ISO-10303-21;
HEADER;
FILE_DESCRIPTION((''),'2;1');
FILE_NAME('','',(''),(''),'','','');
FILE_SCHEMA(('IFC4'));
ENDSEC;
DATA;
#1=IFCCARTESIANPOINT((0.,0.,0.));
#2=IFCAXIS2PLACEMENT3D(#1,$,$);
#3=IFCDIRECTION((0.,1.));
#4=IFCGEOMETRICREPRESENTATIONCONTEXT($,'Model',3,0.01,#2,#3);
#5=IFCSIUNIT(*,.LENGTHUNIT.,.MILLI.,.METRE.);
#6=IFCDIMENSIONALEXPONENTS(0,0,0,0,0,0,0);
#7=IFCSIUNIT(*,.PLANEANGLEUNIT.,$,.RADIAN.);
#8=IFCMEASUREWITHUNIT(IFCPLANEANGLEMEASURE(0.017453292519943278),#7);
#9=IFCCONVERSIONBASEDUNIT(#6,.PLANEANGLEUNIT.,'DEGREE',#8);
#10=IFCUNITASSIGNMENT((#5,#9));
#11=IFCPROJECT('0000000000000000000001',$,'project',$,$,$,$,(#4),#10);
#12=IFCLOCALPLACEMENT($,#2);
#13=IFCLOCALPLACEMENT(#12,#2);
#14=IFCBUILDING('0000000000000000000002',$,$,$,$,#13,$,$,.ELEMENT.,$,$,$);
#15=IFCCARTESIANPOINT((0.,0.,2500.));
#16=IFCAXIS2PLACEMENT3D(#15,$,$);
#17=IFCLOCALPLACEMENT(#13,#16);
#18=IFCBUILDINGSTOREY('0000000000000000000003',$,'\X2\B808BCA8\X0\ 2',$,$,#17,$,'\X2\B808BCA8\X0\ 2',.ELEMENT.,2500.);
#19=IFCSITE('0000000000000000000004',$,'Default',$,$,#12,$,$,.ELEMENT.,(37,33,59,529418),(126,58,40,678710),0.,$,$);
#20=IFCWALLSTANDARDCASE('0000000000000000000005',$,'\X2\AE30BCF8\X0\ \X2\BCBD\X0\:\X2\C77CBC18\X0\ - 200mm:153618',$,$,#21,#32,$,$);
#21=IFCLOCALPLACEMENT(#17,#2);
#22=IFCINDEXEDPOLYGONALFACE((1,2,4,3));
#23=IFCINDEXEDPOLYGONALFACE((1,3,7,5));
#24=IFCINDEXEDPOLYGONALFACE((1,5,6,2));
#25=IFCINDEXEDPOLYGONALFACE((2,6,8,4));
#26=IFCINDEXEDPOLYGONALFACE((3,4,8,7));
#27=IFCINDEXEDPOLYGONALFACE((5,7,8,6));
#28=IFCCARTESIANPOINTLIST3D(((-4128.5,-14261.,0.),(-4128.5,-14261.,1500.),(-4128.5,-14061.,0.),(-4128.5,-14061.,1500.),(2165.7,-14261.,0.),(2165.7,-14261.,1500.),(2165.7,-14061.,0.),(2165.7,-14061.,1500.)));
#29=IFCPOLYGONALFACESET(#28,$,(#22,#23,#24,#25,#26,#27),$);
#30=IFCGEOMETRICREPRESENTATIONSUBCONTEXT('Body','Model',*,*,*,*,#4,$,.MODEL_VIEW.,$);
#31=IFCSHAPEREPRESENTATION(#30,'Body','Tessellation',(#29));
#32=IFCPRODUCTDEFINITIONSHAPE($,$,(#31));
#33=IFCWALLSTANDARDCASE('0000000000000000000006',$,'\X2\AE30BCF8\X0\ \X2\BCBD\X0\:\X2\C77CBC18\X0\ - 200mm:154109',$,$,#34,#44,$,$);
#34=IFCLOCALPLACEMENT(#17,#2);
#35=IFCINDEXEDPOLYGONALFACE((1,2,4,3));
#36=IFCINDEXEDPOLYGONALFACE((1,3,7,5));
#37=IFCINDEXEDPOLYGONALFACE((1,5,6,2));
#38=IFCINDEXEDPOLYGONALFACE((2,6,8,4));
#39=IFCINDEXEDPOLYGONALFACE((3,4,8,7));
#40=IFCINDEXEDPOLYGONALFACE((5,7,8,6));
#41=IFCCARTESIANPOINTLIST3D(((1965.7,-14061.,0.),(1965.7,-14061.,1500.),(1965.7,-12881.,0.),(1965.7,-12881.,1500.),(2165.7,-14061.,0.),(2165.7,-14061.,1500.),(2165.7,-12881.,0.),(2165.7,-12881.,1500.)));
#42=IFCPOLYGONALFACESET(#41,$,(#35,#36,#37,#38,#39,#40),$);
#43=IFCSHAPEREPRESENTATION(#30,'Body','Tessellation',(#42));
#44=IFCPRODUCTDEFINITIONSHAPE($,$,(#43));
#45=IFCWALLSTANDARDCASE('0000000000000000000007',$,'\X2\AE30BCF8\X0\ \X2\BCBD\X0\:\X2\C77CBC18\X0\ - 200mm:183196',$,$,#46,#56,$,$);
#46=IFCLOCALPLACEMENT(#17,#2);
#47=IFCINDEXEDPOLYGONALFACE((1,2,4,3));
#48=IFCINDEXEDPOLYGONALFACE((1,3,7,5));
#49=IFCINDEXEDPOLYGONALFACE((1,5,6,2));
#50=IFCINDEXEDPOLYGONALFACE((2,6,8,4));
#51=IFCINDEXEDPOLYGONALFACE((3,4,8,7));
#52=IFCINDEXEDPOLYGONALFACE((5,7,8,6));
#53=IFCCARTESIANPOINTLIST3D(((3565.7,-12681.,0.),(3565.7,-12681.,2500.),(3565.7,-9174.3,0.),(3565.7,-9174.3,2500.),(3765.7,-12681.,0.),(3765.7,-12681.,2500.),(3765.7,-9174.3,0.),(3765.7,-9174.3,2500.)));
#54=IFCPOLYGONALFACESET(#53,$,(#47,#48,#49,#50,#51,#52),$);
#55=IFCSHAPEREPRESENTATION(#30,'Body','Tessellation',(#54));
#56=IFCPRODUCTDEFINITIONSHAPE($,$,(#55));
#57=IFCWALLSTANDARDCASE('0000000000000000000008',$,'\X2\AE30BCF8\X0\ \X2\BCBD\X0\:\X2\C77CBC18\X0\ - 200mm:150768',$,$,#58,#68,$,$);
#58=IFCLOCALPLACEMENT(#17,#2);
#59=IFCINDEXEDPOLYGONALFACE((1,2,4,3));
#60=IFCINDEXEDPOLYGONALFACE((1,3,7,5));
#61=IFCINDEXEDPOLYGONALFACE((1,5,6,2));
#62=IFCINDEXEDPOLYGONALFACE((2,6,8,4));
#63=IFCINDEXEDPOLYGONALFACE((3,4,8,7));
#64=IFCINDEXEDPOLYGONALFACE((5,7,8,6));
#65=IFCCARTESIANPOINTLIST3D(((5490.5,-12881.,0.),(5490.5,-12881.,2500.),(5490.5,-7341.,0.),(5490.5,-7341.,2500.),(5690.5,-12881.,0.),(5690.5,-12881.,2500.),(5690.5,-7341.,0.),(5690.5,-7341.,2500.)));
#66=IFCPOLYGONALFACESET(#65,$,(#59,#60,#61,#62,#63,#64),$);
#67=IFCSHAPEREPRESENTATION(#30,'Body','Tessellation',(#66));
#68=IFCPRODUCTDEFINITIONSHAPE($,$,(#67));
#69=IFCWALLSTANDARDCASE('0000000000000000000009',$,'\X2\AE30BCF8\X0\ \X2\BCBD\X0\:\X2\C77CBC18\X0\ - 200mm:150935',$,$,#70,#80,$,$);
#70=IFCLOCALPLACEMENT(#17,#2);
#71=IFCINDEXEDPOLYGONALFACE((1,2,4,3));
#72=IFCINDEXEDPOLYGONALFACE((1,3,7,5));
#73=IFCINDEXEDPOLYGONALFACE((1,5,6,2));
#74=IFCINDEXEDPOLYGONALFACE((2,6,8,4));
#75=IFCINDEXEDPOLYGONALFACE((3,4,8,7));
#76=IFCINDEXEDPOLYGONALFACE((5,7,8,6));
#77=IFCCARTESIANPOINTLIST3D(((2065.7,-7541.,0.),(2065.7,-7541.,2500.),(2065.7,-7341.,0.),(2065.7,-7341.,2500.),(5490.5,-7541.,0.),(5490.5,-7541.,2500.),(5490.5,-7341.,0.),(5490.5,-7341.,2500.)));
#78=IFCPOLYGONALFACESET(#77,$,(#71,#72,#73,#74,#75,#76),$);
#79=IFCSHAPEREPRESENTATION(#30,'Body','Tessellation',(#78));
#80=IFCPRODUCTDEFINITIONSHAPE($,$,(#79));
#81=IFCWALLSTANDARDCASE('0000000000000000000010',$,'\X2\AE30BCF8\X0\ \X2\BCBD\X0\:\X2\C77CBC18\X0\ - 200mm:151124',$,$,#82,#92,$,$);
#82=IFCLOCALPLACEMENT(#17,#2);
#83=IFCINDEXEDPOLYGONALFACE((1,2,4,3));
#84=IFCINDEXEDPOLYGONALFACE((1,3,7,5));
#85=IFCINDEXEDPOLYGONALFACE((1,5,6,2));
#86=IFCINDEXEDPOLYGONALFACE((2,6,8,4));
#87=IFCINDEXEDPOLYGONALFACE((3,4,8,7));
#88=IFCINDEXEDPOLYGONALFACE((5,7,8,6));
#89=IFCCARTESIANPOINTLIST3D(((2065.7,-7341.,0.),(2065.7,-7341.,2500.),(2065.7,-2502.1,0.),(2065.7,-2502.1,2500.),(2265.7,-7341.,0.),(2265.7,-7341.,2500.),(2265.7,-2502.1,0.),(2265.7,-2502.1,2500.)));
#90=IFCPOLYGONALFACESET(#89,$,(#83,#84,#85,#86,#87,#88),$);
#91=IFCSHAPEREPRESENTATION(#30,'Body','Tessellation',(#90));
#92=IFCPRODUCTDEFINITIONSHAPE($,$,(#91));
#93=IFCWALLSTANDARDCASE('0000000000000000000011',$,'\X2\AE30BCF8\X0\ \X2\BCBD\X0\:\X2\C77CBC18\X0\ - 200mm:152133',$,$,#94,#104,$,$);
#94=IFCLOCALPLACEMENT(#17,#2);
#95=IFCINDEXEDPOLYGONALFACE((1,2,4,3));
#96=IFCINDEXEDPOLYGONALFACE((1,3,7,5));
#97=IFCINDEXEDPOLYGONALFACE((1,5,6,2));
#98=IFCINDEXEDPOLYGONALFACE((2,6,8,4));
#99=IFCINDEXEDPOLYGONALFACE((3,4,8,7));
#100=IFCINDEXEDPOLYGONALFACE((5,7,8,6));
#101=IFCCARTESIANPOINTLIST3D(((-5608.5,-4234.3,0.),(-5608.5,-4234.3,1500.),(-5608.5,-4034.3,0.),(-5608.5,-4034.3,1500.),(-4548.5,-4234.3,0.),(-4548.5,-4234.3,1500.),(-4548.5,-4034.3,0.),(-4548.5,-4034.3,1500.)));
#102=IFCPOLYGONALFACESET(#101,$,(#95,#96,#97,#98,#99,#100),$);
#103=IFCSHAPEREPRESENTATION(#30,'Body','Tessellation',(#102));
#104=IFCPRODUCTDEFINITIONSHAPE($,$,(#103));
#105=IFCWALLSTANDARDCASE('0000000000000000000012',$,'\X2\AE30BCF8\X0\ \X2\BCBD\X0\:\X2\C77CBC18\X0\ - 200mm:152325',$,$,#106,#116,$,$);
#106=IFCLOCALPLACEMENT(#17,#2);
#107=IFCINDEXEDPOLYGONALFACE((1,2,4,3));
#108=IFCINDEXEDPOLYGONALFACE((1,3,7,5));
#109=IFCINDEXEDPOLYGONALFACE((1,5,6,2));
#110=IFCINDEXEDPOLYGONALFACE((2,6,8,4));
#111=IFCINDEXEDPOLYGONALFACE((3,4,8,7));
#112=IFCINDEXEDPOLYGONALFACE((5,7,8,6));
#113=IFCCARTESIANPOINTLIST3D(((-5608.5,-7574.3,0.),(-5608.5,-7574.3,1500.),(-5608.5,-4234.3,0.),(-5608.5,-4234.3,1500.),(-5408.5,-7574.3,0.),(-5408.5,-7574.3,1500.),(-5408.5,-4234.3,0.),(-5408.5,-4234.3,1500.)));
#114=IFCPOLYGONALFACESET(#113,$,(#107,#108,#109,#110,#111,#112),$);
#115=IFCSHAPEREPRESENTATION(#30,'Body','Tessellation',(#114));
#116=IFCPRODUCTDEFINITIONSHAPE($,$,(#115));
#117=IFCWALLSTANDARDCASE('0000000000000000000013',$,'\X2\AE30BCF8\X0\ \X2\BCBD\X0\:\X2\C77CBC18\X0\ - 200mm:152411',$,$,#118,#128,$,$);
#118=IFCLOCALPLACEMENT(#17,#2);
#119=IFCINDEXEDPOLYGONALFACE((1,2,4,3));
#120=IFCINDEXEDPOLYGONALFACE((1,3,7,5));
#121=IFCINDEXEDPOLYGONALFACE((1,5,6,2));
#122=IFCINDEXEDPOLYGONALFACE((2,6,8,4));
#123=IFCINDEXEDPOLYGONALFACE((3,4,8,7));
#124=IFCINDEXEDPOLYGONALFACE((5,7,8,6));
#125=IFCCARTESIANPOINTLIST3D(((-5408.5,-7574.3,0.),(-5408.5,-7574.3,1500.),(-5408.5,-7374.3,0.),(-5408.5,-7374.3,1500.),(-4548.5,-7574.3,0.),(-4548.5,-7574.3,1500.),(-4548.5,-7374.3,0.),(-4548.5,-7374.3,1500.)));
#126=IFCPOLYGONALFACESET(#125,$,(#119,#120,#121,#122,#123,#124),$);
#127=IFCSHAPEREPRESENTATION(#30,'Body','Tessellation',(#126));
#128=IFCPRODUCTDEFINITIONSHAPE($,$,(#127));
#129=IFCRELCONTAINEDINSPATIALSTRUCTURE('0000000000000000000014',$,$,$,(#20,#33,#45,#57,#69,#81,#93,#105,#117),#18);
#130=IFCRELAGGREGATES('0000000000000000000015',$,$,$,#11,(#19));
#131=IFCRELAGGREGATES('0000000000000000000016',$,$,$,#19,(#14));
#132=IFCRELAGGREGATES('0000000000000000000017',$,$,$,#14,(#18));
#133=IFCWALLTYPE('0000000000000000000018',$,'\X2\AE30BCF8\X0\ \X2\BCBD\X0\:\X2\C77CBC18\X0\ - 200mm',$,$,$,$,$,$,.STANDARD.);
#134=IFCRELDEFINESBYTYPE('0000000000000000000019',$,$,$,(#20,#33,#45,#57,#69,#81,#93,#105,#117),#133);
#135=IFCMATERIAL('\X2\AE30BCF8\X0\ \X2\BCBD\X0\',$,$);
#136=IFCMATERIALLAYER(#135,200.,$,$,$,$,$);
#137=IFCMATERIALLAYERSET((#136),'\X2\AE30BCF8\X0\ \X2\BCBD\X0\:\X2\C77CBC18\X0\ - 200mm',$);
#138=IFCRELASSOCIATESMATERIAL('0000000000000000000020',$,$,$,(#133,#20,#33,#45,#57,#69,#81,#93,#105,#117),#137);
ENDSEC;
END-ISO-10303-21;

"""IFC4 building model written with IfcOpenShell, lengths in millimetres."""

from ifc_helpers import new_model, entity, si_unit, converted_unit, direction, frame, frame_2d, origin, place, context, subcontext, project, spatial, rectangle, extrude, material, layer, layer_set, layer_usage, type_object, element, save


model = new_model("IFC4")

# Units and contexts
model_context = context("Model", 3, precision=0.01, world=origin(), true_north=direction((0.0, 1.0)))
body_context = subcontext(model_context, "Body", "Model", "MODEL_VIEW")
ifc_project = project(units=[si_unit("LENGTHUNIT", "METRE", prefix="MILLI"), converted_unit("PLANEANGLEUNIT", "DEGREE", entity("IfcPlaneAngleMeasure", 0.017453292519943278), si_unit("PLANEANGLEUNIT", "RADIAN"), dimensions=[0, 0, 0, 0, 0, 0, 0])], contexts=[model_context])

# Site, building, storey
site_placement = place(None, origin())
site = spatial("IfcSite", under=ifc_project, at=site_placement, Name="Default", CompositionType="ELEMENT", RefLatitude=(37, 33, 59, 529418), RefLongitude=(126, 58, 40, 678710), RefElevation=0.0)
building_placement = place(site_placement, origin())
building = spatial("IfcBuilding", under=site, at=building_placement, CompositionType="ELEMENT")
storey_placement = place(building_placement, frame((0.0, 0.0, 2500.0)))
storey = spatial("IfcBuildingStorey", under=building, at=storey_placement, Name="레벨 2", LongName="레벨 2", CompositionType="ELEMENT", Elevation=2500.0)

# Shared definitions
ifc_material_1 = material(Name="기본 벽")
ifc_layer_1 = layer(ifc_material_1, 200.0)
ifc_layer_set_1 = layer_set([ifc_layer_1], Name="기본 벽:일반 - 200mm")
wall_type = type_object("IfcWallType", Name="기본 벽:일반 - 200mm", PredefinedType="STANDARD", material=ifc_layer_set_1)

# Walls
ifc_layer_usage_1 = layer_usage(ifc_layer_set_1, "AXIS2", "NEGATIVE", 100.0)
wall_1_placement = place(storey_placement, frame((-4128.5, -14161.0, 0.0)))
element("IfcWallStandardCase", 1, at=wall_1_placement, inside=storey, type_object=wall_type, material=ifc_layer_usage_1, Name="기본 벽:일반 - 200mm:153618", context=body_context, shape_type="SweptSolid", body=[
    extrude(rectangle(XDim=6294.2, YDim=200.0, at=frame_2d((3147.1, 0.0), x_axis=(-1.0, 0.0))), origin(), (0.0, 0.0, 1.0), 1500.0),
])
ifc_layer_usage_2 = layer_usage(ifc_layer_set_1, "AXIS2", "NEGATIVE", 100.0)
wall_2_placement = place(storey_placement, frame((2065.7, -14061.0, 0.0), z_axis=(0.0, 0.0, 1.0), x_axis=(0.0, 1.0, 0.0)))
element("IfcWallStandardCase", 2, at=wall_2_placement, inside=storey, type_object=wall_type, material=ifc_layer_usage_2, Name="기본 벽:일반 - 200mm:154109", context=body_context, shape_type="SweptSolid", body=[
    extrude(rectangle(XDim=1180.0, YDim=200.0, at=frame_2d((590.0, 0.0), x_axis=(-1.0, 0.0))), origin(), (0.0, 0.0, 1.0), 1500.0),
])
ifc_layer_usage_3 = layer_usage(ifc_layer_set_1, "AXIS2", "NEGATIVE", 100.0)
wall_3_placement = place(storey_placement, frame((3665.7, -9174.3, 0.0), z_axis=(0.0, 0.0, 1.0), x_axis=(0.0, -1.0, 0.0)))
element("IfcWallStandardCase", 3, at=wall_3_placement, inside=storey, type_object=wall_type, material=ifc_layer_usage_3, Name="기본 벽:일반 - 200mm:183196", context=body_context, shape_type="SweptSolid", body=[
    extrude(rectangle(XDim=3506.6, YDim=200.0, at=frame_2d((1753.3, 0.0), x_axis=(-1.0, 0.0))), origin(), (0.0, 0.0, 1.0), 2500.0),
])
ifc_layer_usage_4 = layer_usage(ifc_layer_set_1, "AXIS2", "NEGATIVE", 100.0)
wall_4_placement = place(storey_placement, frame((5590.5, -12881.0, 0.0), z_axis=(0.0, 0.0, 1.0), x_axis=(0.0, 1.0, 0.0)))
element("IfcWallStandardCase", 4, at=wall_4_placement, inside=storey, type_object=wall_type, material=ifc_layer_usage_4, Name="기본 벽:일반 - 200mm:150768", context=body_context, shape_type="SweptSolid", body=[
    extrude(rectangle(XDim=5540.0, YDim=200.0, at=frame_2d((2770.0, 0.0), x_axis=(-1.0, 0.0))), origin(), (0.0, 0.0, 1.0), 2500.0),
])
ifc_layer_usage_5 = layer_usage(ifc_layer_set_1, "AXIS2", "NEGATIVE", 100.0)
wall_5_placement = place(storey_placement, frame((5490.5, -7441.0, 0.0), z_axis=(0.0, 0.0, 1.0), x_axis=(-1.0, 0.0, 0.0)))
element("IfcWallStandardCase", 5, at=wall_5_placement, inside=storey, type_object=wall_type, material=ifc_layer_usage_5, Name="기본 벽:일반 - 200mm:150935", context=body_context, shape_type="SweptSolid", body=[
    extrude(rectangle(XDim=3424.8, YDim=200.0, at=frame_2d((1712.4, 0.0), x_axis=(-1.0, 0.0))), origin(), (0.0, 0.0, 1.0), 2500.0),
])
ifc_layer_usage_6 = layer_usage(ifc_layer_set_1, "AXIS2", "NEGATIVE", 100.0)
wall_6_placement = place(storey_placement, frame((2165.7, -7341.0, 0.0), z_axis=(0.0, 0.0, 1.0), x_axis=(0.0, 1.0, 0.0)))
element("IfcWallStandardCase", 6, at=wall_6_placement, inside=storey, type_object=wall_type, material=ifc_layer_usage_6, Name="기본 벽:일반 - 200mm:151124", context=body_context, shape_type="SweptSolid", body=[
    extrude(rectangle(XDim=4838.9, YDim=200.0, at=frame_2d((2419.4, 0.0), x_axis=(-1.0, 0.0))), origin(), (0.0, 0.0, 1.0), 2500.0),
])
ifc_layer_usage_7 = layer_usage(ifc_layer_set_1, "AXIS2", "NEGATIVE", 100.0)
wall_7_placement = place(storey_placement, frame((-4548.5, -4134.3, 0.0), z_axis=(0.0, 0.0, 1.0), x_axis=(-1.0, 0.0, 0.0)))
element("IfcWallStandardCase", 7, at=wall_7_placement, inside=storey, type_object=wall_type, material=ifc_layer_usage_7, Name="기본 벽:일반 - 200mm:152133", context=body_context, shape_type="SweptSolid", body=[
    extrude(rectangle(XDim=1060.0, YDim=200.0, at=frame_2d((530.0, 0.0), x_axis=(-1.0, 0.0))), origin(), (0.0, 0.0, 1.0), 1500.0),
])
ifc_layer_usage_8 = layer_usage(ifc_layer_set_1, "AXIS2", "NEGATIVE", 100.0)
wall_8_placement = place(storey_placement, frame((-5508.5, -4234.3, 0.0), z_axis=(0.0, 0.0, 1.0), x_axis=(0.0, -1.0, 0.0)))
element("IfcWallStandardCase", 8, at=wall_8_placement, inside=storey, type_object=wall_type, material=ifc_layer_usage_8, Name="기본 벽:일반 - 200mm:152325", context=body_context, shape_type="SweptSolid", body=[
    extrude(rectangle(XDim=3340.0, YDim=200.0, at=frame_2d((1670.0, 0.0), x_axis=(-1.0, 0.0))), origin(), (0.0, 0.0, 1.0), 1500.0),
])
ifc_layer_usage_9 = layer_usage(ifc_layer_set_1, "AXIS2", "NEGATIVE", 100.0)
wall_9_placement = place(storey_placement, frame((-5408.5, -7474.3, 0.0)))
element("IfcWallStandardCase", 9, at=wall_9_placement, inside=storey, type_object=wall_type, material=ifc_layer_usage_9, Name="기본 벽:일반 - 200mm:152411", context=body_context, shape_type="SweptSolid", body=[
    extrude(rectangle(XDim=860.0, YDim=200.0, at=frame_2d((430.0, 0.0), x_axis=(-1.0, 0.0))), origin(), (0.0, 0.0, 1.0), 1500.0),
])

save(model, "model.ifc")
